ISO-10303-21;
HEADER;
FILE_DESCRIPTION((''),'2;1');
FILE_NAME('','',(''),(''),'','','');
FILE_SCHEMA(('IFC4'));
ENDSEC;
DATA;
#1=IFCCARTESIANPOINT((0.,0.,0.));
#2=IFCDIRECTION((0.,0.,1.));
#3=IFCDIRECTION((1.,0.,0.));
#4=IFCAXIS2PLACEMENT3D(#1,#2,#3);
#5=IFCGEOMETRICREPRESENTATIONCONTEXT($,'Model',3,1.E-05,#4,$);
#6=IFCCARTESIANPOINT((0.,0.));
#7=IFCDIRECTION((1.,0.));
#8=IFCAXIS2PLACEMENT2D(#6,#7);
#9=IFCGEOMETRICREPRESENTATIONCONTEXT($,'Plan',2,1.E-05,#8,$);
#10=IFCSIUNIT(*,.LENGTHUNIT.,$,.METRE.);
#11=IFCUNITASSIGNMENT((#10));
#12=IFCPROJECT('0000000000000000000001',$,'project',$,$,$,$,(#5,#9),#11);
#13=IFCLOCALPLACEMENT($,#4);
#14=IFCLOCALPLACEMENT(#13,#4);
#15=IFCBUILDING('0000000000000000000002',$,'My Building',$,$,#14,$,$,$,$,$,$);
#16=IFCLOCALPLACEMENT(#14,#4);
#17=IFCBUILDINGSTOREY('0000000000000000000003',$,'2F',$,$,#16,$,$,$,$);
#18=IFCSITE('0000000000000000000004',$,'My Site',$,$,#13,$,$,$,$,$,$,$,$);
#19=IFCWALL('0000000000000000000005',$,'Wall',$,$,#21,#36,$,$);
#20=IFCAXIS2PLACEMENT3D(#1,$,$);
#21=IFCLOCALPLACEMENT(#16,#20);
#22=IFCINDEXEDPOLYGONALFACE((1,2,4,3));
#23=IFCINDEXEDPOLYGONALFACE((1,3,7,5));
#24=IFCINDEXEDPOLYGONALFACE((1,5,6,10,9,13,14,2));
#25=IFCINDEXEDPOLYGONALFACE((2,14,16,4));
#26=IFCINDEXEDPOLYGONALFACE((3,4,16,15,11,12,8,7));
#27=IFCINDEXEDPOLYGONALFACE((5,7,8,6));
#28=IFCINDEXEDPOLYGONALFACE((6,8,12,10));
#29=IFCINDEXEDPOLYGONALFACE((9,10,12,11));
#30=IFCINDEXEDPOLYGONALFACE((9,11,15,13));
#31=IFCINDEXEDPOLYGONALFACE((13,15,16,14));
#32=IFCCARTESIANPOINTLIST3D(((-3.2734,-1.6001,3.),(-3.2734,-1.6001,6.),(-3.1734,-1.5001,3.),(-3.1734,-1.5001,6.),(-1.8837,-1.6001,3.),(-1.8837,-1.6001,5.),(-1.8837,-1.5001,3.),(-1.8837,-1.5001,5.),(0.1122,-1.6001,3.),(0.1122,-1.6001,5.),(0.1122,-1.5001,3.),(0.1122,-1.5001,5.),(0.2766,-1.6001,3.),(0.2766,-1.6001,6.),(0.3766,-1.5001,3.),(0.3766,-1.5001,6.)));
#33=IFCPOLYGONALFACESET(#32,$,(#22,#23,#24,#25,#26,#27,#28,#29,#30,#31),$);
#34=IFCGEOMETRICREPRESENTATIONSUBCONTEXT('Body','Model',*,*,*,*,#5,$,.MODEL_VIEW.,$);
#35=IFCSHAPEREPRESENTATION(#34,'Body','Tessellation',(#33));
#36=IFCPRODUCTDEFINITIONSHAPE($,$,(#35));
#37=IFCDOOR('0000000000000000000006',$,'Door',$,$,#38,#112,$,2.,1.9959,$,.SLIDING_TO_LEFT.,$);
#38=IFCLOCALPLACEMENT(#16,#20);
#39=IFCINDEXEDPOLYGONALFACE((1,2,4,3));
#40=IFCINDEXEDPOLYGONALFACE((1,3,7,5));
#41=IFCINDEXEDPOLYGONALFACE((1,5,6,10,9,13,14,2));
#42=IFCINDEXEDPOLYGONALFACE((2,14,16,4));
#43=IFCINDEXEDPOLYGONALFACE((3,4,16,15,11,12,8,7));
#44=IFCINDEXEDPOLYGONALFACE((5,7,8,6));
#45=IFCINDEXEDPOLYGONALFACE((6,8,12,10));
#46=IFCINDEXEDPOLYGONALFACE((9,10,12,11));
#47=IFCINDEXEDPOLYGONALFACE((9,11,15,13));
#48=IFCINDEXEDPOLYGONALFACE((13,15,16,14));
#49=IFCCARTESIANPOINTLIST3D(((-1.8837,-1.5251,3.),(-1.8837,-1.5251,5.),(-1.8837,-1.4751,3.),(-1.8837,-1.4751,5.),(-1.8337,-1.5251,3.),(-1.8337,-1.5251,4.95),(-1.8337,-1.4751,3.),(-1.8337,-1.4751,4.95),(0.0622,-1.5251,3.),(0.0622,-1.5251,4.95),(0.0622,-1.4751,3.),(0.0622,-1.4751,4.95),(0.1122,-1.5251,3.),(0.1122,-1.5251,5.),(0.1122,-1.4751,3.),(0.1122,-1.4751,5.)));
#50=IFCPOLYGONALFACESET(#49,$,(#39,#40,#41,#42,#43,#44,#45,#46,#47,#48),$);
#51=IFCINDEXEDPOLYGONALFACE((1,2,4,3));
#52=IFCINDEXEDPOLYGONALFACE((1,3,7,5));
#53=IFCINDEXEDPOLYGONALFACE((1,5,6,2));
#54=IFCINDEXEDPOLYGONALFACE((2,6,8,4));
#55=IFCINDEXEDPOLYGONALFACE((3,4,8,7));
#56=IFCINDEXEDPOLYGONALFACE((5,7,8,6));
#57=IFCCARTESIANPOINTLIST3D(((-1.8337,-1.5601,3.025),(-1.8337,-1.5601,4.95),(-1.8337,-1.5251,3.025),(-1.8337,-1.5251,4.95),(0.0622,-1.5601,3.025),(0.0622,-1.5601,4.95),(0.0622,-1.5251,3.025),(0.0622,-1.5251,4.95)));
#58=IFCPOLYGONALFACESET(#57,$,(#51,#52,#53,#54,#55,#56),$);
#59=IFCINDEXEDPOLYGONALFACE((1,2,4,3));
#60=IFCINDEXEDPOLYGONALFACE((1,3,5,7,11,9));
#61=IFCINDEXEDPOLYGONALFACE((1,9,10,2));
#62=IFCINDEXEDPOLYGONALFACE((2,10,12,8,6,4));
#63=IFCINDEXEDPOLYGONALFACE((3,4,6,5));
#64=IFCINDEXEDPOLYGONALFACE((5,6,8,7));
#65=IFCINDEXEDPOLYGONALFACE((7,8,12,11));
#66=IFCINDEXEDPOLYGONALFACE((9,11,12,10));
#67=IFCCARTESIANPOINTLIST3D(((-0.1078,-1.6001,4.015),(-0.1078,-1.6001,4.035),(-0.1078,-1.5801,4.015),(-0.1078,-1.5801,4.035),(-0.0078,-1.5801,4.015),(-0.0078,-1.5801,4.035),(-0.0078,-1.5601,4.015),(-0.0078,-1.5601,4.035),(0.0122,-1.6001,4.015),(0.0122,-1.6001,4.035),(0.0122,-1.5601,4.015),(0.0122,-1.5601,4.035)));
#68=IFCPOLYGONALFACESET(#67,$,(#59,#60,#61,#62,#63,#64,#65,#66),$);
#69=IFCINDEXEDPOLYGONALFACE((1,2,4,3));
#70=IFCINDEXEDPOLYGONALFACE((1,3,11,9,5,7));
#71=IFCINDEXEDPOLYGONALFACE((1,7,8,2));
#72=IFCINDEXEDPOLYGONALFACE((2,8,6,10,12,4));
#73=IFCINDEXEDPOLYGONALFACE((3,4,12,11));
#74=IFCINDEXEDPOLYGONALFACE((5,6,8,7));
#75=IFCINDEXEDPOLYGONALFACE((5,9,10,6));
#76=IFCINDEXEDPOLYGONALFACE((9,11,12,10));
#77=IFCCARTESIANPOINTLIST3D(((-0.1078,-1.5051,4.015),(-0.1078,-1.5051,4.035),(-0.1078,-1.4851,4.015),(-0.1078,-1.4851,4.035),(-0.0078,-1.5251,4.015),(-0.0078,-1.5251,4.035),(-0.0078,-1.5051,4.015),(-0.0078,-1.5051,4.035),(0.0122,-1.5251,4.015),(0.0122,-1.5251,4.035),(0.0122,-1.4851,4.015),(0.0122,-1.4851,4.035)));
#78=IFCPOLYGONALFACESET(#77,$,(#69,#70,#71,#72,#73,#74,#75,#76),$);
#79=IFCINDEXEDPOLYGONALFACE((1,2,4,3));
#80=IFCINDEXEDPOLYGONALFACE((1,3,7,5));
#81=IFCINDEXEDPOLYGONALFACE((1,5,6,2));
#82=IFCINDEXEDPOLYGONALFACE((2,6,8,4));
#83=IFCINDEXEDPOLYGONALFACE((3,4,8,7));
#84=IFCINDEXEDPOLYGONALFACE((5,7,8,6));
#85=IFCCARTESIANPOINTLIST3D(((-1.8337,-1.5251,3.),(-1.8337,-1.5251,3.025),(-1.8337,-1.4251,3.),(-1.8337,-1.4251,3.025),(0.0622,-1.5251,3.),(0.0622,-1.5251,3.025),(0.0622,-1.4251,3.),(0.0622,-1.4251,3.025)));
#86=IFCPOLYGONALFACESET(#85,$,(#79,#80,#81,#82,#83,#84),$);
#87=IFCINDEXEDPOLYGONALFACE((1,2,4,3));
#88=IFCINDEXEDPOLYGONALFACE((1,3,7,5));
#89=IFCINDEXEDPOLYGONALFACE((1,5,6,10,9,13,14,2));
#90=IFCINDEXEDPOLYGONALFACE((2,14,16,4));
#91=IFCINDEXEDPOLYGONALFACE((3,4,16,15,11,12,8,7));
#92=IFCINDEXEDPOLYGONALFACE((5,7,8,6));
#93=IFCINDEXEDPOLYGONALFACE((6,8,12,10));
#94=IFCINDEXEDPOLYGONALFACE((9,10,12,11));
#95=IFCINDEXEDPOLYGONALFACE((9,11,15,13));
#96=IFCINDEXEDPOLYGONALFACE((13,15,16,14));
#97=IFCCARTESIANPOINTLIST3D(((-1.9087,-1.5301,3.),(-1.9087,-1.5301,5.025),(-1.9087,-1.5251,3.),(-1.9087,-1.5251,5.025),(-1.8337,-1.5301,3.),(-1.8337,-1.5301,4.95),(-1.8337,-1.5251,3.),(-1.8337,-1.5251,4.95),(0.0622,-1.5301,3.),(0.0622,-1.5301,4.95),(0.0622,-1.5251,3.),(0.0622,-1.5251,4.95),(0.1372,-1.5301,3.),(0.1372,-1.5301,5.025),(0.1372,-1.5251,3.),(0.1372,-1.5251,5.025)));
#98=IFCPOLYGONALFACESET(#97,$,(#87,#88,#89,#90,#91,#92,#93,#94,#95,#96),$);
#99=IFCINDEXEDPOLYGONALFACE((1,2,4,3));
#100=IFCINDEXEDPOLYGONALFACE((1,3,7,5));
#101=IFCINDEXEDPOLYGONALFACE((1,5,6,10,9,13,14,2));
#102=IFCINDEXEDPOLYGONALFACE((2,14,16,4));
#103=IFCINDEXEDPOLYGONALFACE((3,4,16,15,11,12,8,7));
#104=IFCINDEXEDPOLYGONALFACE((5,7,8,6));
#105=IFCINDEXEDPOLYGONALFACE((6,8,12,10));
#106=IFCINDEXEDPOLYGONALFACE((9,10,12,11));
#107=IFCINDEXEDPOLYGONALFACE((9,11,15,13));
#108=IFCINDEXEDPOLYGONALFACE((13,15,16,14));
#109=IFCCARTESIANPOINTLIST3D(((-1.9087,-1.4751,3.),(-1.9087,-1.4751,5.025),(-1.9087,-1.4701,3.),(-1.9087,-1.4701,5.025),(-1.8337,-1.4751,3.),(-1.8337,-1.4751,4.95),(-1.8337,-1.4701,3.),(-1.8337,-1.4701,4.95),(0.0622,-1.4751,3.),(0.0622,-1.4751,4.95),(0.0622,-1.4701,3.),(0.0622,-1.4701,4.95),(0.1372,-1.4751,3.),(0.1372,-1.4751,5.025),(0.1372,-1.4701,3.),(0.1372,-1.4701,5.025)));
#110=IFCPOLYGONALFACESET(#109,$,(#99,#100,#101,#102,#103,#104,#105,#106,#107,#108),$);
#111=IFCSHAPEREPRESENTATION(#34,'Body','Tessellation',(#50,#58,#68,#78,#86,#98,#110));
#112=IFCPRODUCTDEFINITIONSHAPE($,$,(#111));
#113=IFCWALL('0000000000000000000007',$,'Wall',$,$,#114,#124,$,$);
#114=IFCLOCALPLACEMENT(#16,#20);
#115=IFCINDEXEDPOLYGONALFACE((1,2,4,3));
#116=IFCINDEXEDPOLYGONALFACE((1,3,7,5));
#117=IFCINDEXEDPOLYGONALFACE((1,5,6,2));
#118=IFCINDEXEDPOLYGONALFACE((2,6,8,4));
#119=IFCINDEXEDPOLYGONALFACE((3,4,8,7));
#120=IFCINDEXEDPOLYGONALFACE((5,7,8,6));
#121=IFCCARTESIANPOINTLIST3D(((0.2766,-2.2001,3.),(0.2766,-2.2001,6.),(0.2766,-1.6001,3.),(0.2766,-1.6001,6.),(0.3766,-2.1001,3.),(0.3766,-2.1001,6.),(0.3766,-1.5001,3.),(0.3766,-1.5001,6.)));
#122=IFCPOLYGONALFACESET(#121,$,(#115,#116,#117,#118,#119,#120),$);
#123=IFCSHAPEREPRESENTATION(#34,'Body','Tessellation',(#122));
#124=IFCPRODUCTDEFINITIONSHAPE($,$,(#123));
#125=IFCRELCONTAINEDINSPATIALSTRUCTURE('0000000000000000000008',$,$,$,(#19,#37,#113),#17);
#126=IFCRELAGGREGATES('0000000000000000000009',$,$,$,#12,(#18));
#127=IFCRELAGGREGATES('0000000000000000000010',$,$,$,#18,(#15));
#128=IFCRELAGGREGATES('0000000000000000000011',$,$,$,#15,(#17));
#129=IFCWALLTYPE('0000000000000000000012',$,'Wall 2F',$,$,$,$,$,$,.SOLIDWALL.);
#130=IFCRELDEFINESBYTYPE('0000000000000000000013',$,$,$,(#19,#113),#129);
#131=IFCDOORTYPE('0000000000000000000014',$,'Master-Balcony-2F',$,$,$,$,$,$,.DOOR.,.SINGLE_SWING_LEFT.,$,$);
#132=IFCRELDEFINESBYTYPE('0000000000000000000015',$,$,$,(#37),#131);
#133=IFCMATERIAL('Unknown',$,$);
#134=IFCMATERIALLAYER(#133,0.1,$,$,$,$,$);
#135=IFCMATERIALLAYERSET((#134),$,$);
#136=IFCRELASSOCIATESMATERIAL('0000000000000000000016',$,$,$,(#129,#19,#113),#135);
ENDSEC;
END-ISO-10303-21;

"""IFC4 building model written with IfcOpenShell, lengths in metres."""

from ifc_helpers import new_model, entity, si_unit, frame, origin_with_axes, origin_2d_with_axis, place, context, subcontext, project, spatial, line, indexed_curve, outline, extrude, shape, source, transform, mapped, material, layer, layer_set, layer_usage, type_object, type_shapes, element, fill, save


model = new_model("IFC4")

# Units and contexts
model_context = context("Model", 3, precision=1e-05, world=origin_with_axes())
plan_context = context("Plan", 2, precision=1e-05, world=origin_2d_with_axis())
body_context_1 = subcontext(model_context, "Body", "Model", "MODEL_VIEW")
body_context_2 = subcontext(plan_context, "Body", "Plan", "PLAN_VIEW")
ifc_project = project(units=[si_unit("LENGTHUNIT", "METRE")], contexts=[model_context, plan_context])

# Site, building, storey
site_placement = place(None, origin_with_axes())
site = spatial("IfcSite", under=ifc_project, at=site_placement, Name="My Site")
building_placement = place(site_placement, origin_with_axes())
building = spatial("IfcBuilding", under=site, at=building_placement, Name="My Building")
storey_placement = place(building_placement, origin_with_axes())
storey = spatial("IfcBuildingStorey", under=building, at=storey_placement, Name="2F")

# Shared definitions
ifc_material = material(Name="Unknown")

# Shared definitions
ifc_layer_1 = layer(ifc_material, 0.1)
ifc_layer_set_1 = layer_set([ifc_layer_1])
wall_type = type_object("IfcWallType", Name="Wall 2F", PredefinedType="SOLIDWALL", material=ifc_layer_set_1)

# Wall, opening, door
ifc_layer_usage_1 = layer_usage(ifc_layer_set_1, "AXIS2", "POSITIVE", 0.0)
wall_1_placement = place(storey_placement, frame((-3.2734, -1.6001, 3.0), z_axis=(0.0, 0.0, 1.0), x_axis=(1.0, 0.0, 0.0)))
wall_1 = element("IfcWall", 1, at=wall_1_placement, inside=storey, type_object=wall_type, material=ifc_layer_usage_1, Name="Wall", context=body_context_1, shape_type="SweptSolid", body=[
    extrude(outline(indexed_curve([(0.0, 0.0), (0.1, 0.1), (3.65, 0.1), (3.55, 0.0)], segments=[line(1, 2, 3, 4, 1)])), origin_with_axes(), (0.0, 0.0, 1.0), 3.0),
])
shared_shape_1 = source(origin_with_axes(), body_context_1, "Body", "SweptSolid", [
    extrude(outline(indexed_curve([(0.0, 0.0), (1.9959, 0.0), (1.9959, 2.0), (0.0, 2.0)], segments=[line(1, 2, 3, 4, 1)])), frame((0.0, -0.6, 0.0), z_axis=(0.0, -1.0, 0.0), x_axis=(1.0, 0.0, 0.0)), (0.0, 0.0, -1.0), 1.2),
])
opening_1_placement = place(wall_1_placement, frame((1.3897, 0.075, 0.0), z_axis=(0.0, 0.0, 1.0), x_axis=(1.0, 0.0, 0.0)))
opening_1 = element("IfcOpeningElement", 2, at=opening_1_placement, cuts=wall_1, PredefinedType="OPENING", context=body_context_1, shape_type="MappedRepresentation", body=[
    mapped(shared_shape_1, transform((0.0, 0.0, 0.0), x_axis=(1.0, 0.0, 0.0), y_axis=(0.0, 1.0, 0.0), z_axis=(0.0, 0.0, 1.0), scale=1.0)),
])
door_type_1 = type_object("IfcDoorType", Name="Master-Balcony-2F", OperationType="SINGLE_SWING_LEFT", PredefinedType="DOOR")
shared_shape_2 = source(origin_with_axes(), body_context_1, "Body", "SweptSolid", [
    extrude(outline(indexed_curve([(0.0, 0.0), (0.0, 2.0), (1.9959, 2.0), (1.9959, 0.0), (1.9459, 0.0), (1.9459, 1.95), (0.05, 1.95), (0.05, 0.0)], segments=[line(1, 2, 3, 4, 5, 6, 7, 8, 1)])), frame((0.0, 0.0, 0.0), z_axis=(0.0, -1.0, 0.0), x_axis=(1.0, 0.0, 0.0)), (0.0, 0.0, -1.0), 0.05),
    extrude(outline(indexed_curve([(0.0, 0.0), (1.8959, 0.0), (1.8959, 0.035), (0.0, 0.035)], segments=[line(1, 2, 3, 4, 1)])), frame((0.05, -0.035, 0.025), z_axis=(0.0, 0.0, 1.0), x_axis=(1.0, 0.0, 0.0)), (0.0, 0.0, 1.0), 1.925),
    extrude(outline(indexed_curve([(0.0, 0.0), (0.0, -0.04), (-0.12, -0.04), (-0.12, -0.02), (-0.02, -0.02), (-0.02, 0.0)], segments=[line(1, 2, 3, 4, 5, 6, 1)])), frame((1.8959, -0.035, 1.015), z_axis=(0.0, 0.0, 1.0), x_axis=(1.0, 0.0, 0.0)), (0.0, 0.0, 1.0), 0.02),
    extrude(outline(indexed_curve([(0.0, 0.0), (0.0, 0.04), (-0.12, 0.04), (-0.12, 0.02), (-0.02, 0.02), (-0.02, 0.0)], segments=[line(1, 2, 3, 4, 5, 6, 1)])), frame((1.8959, 0.0, 1.015), z_axis=(0.0, 0.0, 1.0), x_axis=(1.0, 0.0, 0.0)), (0.0, 0.0, 1.0), 0.02),
    extrude(outline(indexed_curve([(0.0, 0.0), (1.8959, 0.0), (1.8959, 0.1), (0.0, 0.1)], segments=[line(1, 2, 3, 4, 1)])), frame((0.05, 0.0, 0.0), z_axis=(0.0, 0.0, 1.0), x_axis=(1.0, 0.0, 0.0)), (0.0, 0.0, 1.0), 0.025),
    extrude(outline(indexed_curve([(0.0, 0.0), (0.0, 2.025), (2.0459, 2.025), (2.0459, 0.0), (1.9709, 0.0), (1.9709, 1.95), (0.075, 1.95), (0.075, 0.0)], segments=[line(1, 2, 3, 4, 5, 6, 7, 8, 1)])), frame((-0.025, -0.005, 0.0), z_axis=(0.0, -1.0, 0.0), x_axis=(1.0, 0.0, 0.0)), (0.0, 0.0, -1.0), 0.005),
    extrude(outline(indexed_curve([(0.0, 0.0), (0.0, 2.025), (2.0459, 2.025), (2.0459, 0.0), (1.9709, 0.0), (1.9709, 1.95), (0.075, 1.95), (0.075, 0.0)], segments=[line(1, 2, 3, 4, 5, 6, 7, 8, 1)])), frame((-0.025, 0.05, 0.0), z_axis=(0.0, -1.0, 0.0), x_axis=(1.0, 0.0, 0.0)), (0.0, 0.0, -1.0), 0.005),
])
shared_shape_3 = source(origin_with_axes(), body_context_2, "Body", "Curve2D", [
    entity("IfcIndexedPolyCurve", entity("IfcCartesianPointList2D", [[0.0, 0.0], [0.05, 0.0], [0.05, 0.05], [0.0, 0.05]]), [entity("IfcLineIndex", [1, 2, 3, 4, 1])]),
    entity("IfcIndexedPolyCurve", entity("IfcCartesianPointList2D", [[1.9959, 0.0], [1.9459, 0.0], [1.9459, 0.05], [1.9959, 0.05]]), [entity("IfcLineIndex", [1, 2, 3, 4, 1])]),
    entity("IfcIndexedPolyCurve", entity("IfcCartesianPointList2D", [[-0.8979, -0.035], [0.9979, -0.035], [0.9979, 0.0], [-0.8979, 0.0]]), [entity("IfcLineIndex", [1, 2, 3, 4, 1])]),
])
type_shapes(door_type_1, [shared_shape_2, shared_shape_3])
door_1_placement = place(opening_1_placement, frame((0.0, 0.0, 0.0), z_axis=(0.0, 0.0, 1.0), x_axis=(1.0, 0.0, 0.0)))
door_1 = element("IfcDoor", 3, at=door_1_placement, inside=storey, type_object=door_type_1, Name="Door", OperationType="SLIDING_TO_LEFT", OverallHeight=2.0, OverallWidth=1.9959, shapes=[
    shape(body_context_1, "Body", "MappedRepresentation", [mapped(shared_shape_2, transform((0.0, 0.0, 0.0), x_axis=(1.0, 0.0, 0.0), y_axis=(0.0, 1.0, 0.0), z_axis=(0.0, 0.0, 1.0), scale=1.0))]),
    shape(body_context_2, "Body", "MappedRepresentation", [mapped(shared_shape_3, transform((0.0, 0.0, 0.0), x_axis=(1.0, 0.0, 0.0), y_axis=(0.0, 1.0, 0.0), z_axis=(0.0, 0.0, 1.0), scale=1.0))]),
])
fill(opening_1, door_1)

# Wall
ifc_layer_usage_2 = layer_usage(ifc_layer_set_1, "AXIS2", "POSITIVE", 0.0)
wall_2_placement = place(storey_placement, frame((0.2766, -1.6001, 3.0), z_axis=(0.0, 0.0, 1.0), x_axis=(0.0, -1.0, 0.0)))
element("IfcWall", 4, at=wall_2_placement, inside=storey, type_object=wall_type, material=ifc_layer_usage_2, Name="Wall", context=body_context_1, shape_type="SweptSolid", body=[
    extrude(outline(indexed_curve([(0.0, 0.0), (-0.1, 0.1), (0.5, 0.1), (0.6, 0.0)], segments=[line(1, 2, 3, 4, 1)])), origin_with_axes(), (0.0, 0.0, 1.0), 3.0),
])

save(model, "model.ifc")
